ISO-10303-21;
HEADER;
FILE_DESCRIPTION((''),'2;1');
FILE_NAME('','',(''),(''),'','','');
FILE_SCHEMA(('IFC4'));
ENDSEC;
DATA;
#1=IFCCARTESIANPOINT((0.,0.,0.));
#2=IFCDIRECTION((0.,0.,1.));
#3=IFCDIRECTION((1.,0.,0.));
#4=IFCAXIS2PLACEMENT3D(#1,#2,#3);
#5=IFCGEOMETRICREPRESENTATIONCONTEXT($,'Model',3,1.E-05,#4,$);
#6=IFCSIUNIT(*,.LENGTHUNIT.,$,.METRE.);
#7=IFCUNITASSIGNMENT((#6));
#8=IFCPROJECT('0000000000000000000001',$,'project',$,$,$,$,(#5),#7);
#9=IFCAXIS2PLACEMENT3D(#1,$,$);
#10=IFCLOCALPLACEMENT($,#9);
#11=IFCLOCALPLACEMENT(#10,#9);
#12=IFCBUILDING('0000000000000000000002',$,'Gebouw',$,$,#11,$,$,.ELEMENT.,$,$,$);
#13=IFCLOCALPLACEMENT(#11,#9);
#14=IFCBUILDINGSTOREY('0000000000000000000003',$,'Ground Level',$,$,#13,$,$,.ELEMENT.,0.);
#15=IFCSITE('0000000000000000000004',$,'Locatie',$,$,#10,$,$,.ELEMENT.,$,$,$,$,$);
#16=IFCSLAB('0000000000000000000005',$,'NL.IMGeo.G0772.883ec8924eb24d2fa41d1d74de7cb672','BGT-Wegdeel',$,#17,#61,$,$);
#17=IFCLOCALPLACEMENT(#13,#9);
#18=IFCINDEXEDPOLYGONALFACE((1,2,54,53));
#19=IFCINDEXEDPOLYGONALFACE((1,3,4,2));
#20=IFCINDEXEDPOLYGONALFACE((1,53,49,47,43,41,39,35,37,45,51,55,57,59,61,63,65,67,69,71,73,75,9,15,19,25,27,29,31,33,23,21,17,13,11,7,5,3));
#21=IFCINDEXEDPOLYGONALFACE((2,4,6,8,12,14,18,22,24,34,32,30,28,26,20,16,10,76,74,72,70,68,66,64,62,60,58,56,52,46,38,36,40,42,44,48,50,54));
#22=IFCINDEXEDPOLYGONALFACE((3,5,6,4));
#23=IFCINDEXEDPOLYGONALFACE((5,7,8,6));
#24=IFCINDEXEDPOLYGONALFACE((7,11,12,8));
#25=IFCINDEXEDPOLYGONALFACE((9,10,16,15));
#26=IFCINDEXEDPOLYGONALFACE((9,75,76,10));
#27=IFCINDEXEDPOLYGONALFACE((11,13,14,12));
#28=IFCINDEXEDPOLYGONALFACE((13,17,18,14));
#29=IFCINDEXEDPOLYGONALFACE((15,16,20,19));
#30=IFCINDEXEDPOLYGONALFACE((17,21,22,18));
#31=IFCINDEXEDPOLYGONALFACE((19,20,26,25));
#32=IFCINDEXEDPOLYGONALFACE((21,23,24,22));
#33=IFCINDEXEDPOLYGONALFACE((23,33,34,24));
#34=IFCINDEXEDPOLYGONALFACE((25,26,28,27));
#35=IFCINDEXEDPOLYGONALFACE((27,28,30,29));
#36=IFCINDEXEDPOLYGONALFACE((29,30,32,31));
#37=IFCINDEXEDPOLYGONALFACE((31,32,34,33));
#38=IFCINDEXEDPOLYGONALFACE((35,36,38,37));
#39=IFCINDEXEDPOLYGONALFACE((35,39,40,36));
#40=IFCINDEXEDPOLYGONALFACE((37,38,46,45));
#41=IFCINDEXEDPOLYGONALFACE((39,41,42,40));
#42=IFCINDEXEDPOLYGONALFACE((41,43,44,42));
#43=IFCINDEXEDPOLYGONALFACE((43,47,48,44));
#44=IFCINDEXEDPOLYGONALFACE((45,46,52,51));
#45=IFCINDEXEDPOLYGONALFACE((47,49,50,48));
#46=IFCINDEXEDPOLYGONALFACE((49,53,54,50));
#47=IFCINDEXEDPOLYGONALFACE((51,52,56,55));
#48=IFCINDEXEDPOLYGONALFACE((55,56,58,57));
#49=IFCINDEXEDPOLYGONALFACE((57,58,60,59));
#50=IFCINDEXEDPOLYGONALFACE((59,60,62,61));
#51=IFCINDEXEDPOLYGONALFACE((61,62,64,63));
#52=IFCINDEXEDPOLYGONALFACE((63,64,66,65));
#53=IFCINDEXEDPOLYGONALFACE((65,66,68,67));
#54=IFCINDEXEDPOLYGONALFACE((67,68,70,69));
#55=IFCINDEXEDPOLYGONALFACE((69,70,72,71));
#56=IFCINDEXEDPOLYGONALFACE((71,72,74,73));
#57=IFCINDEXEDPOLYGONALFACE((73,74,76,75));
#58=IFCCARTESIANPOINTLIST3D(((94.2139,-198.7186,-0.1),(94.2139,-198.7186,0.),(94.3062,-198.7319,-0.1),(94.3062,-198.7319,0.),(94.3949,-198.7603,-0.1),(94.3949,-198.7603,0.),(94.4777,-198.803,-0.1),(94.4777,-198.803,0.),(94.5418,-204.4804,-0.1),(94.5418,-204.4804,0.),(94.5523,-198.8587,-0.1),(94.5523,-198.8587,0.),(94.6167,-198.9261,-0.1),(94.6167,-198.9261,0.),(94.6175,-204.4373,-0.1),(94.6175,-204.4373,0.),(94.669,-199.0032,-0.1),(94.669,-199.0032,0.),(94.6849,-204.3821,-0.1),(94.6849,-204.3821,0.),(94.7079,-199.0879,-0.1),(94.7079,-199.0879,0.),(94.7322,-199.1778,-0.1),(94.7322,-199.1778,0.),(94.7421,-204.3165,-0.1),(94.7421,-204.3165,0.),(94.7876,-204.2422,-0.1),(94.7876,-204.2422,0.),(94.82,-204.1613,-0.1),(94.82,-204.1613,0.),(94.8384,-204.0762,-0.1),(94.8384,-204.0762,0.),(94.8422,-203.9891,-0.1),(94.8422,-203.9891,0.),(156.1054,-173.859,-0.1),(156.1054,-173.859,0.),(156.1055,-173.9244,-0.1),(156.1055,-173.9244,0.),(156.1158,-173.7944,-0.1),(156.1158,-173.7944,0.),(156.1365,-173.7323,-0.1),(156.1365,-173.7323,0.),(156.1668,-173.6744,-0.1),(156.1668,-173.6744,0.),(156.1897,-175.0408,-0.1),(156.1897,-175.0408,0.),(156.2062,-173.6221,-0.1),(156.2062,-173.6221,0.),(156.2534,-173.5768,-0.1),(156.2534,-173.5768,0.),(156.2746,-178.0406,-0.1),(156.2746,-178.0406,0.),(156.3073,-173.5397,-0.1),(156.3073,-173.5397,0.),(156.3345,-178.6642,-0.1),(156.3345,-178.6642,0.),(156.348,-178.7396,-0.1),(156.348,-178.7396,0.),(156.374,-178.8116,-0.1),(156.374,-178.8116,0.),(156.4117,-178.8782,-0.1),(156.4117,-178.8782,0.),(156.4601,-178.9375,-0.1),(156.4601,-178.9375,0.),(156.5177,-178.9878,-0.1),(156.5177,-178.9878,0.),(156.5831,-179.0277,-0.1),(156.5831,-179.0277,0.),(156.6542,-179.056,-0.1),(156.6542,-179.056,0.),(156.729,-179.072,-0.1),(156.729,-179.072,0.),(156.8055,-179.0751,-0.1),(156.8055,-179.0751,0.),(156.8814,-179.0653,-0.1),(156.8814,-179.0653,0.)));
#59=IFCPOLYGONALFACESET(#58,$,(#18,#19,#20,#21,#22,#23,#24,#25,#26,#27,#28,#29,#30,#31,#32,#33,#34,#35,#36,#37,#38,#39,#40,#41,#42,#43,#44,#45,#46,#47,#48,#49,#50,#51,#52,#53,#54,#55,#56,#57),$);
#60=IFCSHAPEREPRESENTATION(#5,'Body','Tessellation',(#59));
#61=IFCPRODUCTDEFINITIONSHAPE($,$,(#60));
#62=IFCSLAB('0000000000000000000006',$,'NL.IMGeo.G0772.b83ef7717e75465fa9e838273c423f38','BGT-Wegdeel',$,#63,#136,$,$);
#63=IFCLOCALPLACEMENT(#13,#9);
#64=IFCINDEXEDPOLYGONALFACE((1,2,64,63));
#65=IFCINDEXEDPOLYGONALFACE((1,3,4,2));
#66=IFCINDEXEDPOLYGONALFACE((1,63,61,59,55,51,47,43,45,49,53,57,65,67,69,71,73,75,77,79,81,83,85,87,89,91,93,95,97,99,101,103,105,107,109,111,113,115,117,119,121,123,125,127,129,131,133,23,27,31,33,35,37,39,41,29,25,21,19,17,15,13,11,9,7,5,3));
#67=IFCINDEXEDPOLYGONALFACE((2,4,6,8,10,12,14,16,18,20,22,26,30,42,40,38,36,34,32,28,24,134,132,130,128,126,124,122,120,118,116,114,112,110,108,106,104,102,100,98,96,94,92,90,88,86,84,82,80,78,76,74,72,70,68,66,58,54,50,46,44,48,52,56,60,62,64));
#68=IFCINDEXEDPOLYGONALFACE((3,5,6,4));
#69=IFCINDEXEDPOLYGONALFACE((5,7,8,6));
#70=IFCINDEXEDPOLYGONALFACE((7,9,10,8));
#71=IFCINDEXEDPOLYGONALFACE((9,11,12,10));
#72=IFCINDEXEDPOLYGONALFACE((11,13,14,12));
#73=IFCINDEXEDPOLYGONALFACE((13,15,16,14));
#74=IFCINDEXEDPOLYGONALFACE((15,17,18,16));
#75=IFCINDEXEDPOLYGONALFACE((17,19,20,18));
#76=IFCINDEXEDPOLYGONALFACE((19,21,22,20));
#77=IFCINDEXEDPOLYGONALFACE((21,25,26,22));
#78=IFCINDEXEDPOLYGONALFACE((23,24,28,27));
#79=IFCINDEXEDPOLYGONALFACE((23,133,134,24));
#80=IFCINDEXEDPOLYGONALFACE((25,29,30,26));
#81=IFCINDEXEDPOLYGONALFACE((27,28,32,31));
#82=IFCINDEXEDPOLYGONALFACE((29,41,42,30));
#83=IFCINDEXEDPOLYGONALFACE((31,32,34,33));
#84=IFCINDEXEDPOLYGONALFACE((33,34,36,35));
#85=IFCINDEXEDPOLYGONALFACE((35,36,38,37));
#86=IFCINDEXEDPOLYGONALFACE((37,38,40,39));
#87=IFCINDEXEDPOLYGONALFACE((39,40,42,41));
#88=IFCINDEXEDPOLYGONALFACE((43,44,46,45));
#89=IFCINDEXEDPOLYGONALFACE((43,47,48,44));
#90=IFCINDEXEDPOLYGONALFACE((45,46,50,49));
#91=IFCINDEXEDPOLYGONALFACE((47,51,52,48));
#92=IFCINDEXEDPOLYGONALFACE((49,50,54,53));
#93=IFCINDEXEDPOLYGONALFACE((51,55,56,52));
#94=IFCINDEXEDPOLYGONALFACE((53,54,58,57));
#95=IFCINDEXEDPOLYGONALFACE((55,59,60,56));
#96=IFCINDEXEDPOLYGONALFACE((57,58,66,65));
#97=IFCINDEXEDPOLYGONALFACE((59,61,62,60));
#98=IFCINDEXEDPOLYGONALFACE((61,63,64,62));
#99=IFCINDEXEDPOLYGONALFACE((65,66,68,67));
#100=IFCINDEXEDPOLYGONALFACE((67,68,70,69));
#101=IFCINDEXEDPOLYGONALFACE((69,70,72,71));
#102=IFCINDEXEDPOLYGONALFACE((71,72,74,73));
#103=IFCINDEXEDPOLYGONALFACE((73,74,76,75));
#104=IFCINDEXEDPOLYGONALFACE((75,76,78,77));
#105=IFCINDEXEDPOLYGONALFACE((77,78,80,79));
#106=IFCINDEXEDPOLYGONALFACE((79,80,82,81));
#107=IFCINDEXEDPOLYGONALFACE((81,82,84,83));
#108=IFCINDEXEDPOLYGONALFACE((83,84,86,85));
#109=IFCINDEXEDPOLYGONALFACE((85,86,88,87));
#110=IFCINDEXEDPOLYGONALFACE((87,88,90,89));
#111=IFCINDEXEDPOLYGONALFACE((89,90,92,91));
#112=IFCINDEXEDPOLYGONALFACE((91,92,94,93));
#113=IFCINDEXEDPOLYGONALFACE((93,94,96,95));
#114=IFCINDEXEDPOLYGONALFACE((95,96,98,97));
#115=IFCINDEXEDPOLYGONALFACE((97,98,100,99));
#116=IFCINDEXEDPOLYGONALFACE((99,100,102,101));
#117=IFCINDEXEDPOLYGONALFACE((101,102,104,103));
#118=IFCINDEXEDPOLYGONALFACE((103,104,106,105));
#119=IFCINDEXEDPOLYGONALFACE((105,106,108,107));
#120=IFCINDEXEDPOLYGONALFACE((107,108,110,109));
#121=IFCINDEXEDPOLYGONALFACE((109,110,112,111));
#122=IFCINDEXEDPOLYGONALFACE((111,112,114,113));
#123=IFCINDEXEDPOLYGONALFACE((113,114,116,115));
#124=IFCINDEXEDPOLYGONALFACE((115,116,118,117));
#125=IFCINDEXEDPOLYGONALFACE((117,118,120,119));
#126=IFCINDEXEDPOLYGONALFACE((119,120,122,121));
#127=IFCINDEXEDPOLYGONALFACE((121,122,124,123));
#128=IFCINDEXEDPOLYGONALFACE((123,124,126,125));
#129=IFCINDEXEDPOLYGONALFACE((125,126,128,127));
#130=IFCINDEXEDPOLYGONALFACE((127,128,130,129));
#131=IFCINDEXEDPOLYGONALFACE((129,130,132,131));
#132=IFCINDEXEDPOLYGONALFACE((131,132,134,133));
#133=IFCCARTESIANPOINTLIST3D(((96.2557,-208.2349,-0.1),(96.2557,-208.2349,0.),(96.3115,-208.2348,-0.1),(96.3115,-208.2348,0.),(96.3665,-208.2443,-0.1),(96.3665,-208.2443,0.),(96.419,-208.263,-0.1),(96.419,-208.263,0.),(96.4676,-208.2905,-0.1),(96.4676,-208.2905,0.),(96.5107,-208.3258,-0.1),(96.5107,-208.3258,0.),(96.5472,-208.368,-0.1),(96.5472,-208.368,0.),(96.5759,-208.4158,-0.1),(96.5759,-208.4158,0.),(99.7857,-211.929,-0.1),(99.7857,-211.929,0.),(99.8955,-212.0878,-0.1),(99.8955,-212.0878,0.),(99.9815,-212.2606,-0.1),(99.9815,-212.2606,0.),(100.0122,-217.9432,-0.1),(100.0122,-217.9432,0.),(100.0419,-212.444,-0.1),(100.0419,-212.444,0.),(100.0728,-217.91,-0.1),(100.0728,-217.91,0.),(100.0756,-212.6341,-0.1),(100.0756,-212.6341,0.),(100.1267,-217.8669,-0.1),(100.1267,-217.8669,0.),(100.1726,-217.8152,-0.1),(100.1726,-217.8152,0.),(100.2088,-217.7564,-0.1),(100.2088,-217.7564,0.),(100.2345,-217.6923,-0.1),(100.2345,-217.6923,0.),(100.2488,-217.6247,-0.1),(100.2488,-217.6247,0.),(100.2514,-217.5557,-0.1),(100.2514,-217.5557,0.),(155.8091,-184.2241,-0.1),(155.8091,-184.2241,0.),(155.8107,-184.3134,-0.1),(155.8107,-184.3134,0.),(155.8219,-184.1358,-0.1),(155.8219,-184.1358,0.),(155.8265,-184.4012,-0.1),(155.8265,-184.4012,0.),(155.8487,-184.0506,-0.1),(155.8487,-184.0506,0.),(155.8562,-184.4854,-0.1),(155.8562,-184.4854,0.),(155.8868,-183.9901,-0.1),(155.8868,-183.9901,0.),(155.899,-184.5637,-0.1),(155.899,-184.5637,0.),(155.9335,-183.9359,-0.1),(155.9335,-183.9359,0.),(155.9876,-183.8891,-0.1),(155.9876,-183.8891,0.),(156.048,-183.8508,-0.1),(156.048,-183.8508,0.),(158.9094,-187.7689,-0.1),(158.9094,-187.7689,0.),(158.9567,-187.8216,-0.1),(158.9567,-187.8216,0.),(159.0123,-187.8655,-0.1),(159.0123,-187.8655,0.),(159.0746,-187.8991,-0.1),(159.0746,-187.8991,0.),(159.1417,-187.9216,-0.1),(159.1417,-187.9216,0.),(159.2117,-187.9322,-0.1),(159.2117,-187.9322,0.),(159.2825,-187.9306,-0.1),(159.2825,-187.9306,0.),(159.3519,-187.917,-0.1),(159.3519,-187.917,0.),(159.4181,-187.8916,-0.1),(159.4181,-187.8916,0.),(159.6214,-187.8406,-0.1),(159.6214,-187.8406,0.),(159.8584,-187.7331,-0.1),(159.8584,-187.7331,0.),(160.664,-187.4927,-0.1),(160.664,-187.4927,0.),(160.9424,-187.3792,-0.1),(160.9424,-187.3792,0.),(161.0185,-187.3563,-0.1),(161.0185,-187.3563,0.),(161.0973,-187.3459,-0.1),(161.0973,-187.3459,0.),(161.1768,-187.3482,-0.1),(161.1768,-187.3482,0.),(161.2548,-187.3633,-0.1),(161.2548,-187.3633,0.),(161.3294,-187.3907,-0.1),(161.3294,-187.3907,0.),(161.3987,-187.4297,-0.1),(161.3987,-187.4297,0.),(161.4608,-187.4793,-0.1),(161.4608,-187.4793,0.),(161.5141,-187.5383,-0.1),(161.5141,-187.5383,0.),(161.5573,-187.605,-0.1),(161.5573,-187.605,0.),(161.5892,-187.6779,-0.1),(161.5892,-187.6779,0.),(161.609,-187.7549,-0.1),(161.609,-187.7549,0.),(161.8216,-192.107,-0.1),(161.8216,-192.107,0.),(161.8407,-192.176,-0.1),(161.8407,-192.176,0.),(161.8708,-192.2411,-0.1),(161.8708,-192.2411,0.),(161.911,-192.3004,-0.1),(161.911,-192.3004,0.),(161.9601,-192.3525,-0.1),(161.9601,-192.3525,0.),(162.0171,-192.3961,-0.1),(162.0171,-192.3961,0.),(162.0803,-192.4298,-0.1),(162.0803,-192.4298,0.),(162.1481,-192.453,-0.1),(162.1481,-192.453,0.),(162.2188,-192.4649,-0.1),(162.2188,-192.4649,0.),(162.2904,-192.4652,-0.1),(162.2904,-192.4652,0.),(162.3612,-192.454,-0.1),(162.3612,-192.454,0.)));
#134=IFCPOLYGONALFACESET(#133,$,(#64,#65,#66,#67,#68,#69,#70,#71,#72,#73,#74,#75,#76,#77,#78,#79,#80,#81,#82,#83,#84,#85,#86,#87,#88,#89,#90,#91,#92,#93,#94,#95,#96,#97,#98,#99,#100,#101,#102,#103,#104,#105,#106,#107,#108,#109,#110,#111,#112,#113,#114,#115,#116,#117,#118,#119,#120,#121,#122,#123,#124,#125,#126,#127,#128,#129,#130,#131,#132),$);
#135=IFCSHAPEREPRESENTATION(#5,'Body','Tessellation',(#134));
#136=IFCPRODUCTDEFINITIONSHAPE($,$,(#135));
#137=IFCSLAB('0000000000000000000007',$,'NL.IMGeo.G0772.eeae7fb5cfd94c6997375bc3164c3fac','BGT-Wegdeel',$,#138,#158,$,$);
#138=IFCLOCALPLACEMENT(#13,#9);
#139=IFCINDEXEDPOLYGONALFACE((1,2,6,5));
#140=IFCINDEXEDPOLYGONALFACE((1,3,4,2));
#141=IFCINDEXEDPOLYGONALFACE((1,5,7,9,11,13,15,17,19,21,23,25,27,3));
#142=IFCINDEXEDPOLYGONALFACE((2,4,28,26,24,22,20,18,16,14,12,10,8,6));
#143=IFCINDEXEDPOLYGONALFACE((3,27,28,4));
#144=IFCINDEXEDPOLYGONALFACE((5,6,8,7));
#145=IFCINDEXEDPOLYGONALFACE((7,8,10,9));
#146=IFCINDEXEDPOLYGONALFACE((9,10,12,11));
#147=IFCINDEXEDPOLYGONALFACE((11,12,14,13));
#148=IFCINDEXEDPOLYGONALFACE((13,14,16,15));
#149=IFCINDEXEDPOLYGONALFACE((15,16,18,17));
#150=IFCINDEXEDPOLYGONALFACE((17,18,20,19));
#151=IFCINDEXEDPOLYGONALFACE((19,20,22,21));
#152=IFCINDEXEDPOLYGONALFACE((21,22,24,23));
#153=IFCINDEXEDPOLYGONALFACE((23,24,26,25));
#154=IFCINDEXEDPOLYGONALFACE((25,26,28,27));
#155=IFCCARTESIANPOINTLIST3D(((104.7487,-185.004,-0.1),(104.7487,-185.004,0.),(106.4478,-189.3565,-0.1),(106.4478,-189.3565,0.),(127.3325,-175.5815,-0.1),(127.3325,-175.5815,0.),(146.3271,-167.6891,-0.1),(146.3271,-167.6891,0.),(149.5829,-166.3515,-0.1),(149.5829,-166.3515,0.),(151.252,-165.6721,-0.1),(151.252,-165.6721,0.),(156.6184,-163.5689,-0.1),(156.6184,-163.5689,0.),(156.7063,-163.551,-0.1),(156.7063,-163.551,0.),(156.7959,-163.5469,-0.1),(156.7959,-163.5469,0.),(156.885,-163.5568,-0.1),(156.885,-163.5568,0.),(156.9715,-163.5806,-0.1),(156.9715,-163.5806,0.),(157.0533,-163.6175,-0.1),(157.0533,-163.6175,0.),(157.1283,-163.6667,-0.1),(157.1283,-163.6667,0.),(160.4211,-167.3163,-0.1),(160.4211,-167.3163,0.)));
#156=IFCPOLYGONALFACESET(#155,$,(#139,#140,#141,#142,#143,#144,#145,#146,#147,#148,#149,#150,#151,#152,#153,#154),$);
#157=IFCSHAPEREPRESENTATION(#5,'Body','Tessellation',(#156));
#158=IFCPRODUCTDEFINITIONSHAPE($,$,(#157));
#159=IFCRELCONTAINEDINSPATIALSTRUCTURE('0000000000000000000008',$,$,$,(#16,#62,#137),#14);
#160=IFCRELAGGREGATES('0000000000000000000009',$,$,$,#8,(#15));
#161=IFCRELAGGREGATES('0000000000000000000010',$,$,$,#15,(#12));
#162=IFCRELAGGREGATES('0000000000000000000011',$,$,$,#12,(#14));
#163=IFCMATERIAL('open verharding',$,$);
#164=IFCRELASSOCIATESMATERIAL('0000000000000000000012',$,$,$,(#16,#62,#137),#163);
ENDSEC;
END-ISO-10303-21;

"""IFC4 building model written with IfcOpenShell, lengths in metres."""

from ifc_helpers import new_model, si_unit, frame, origin, origin_with_axes, place, context, project, spatial, polyline, outline, extrude, material, element, save


model = new_model("IFC4")

# Units and contexts
model_context = context("Model", 3, precision=1e-05, world=origin_with_axes())
ifc_project = project(units=[si_unit("LENGTHUNIT", "METRE")], contexts=[model_context])

# Site, building, storey
site_placement = place(None, origin())
site = spatial("IfcSite", under=ifc_project, at=site_placement, Name="Locatie", CompositionType="ELEMENT")
building_placement = place(site_placement, origin())
building = spatial("IfcBuilding", under=site, at=building_placement, Name="Gebouw", CompositionType="ELEMENT")
storey_placement = place(building_placement, origin())
storey = spatial("IfcBuildingStorey", under=building, at=storey_placement, Name="Ground Level", CompositionType="ELEMENT", Elevation=0.0)

# Slabs
ifc_material_1 = material(Name="open verharding")
slab_1_placement = place(storey_placement, origin())
element("IfcSlab", 1, at=slab_1_placement, inside=storey, material=ifc_material_1, Name="NL.IMGeo.G0772.883ec8924eb24d2fa41d1d74de7cb672", Description="BGT-Wegdeel", context=model_context, shape_type="SweptSolid", body=[
    extrude(outline(polyline([(156.3073, -173.5397), (156.2534, -173.5768), (156.2062, -173.6221), (156.1668, -173.6744), (156.1365, -173.7323), (156.1158, -173.7944), (156.1054, -173.859), (156.1055, -173.9244), (156.1897, -175.0408), (156.2746, -178.0406), (156.3345, -178.6642), (156.348, -178.7396), (156.374, -178.8116), (156.4117, -178.8782), (156.4601, -178.9375), (156.5177, -178.9878), (156.5831, -179.0277), (156.6542, -179.056), (156.729, -179.072), (156.8055, -179.0751), (156.8814, -179.0653), (94.5418, -204.4804), (94.6175, -204.4373), (94.6849, -204.3821), (94.7421, -204.3165), (94.7876, -204.2422), (94.82, -204.1613), (94.8384, -204.0762), (94.8422, -203.9891), (94.7322, -199.1778), (94.7079, -199.0879), (94.669, -199.0032), (94.6167, -198.9261), (94.5523, -198.8587), (94.4777, -198.803), (94.3949, -198.7603), (94.3062, -198.7319), (94.2139, -198.7186), (156.3073, -173.5397)])), frame((0.0, 0.0, -0.1), z_axis=(0.0, 0.0, 1.0), x_axis=(1.0, 0.0, 0.0)), (0.0, 0.0, 1.0), 0.1),
])
slab_2_placement = place(storey_placement, origin())
element("IfcSlab", 2, at=slab_2_placement, inside=storey, material=ifc_material_1, Name="NL.IMGeo.G0772.b83ef7717e75465fa9e838273c423f38", Description="BGT-Wegdeel", context=model_context, shape_type="SweptSolid", body=[
    extrude(outline(polyline([(156.048, -183.8508), (155.9876, -183.8891), (155.9335, -183.9359), (155.8868, -183.9901), (155.8487, -184.0506), (155.8219, -184.1358), (155.8091, -184.2241), (155.8107, -184.3134), (155.8265, -184.4012), (155.8562, -184.4854), (155.899, -184.5637), (158.9094, -187.7689), (158.9567, -187.8216), (159.0123, -187.8655), (159.0746, -187.8991), (159.1417, -187.9216), (159.2117, -187.9322), (159.2825, -187.9306), (159.3519, -187.917), (159.4181, -187.8916), (159.6214, -187.8406), (159.8584, -187.7331), (160.664, -187.4927), (160.9424, -187.3792), (161.0185, -187.3563), (161.0973, -187.3459), (161.1768, -187.3482), (161.2548, -187.3633), (161.3294, -187.3907), (161.3987, -187.4297), (161.4608, -187.4793), (161.5141, -187.5383), (161.5573, -187.605), (161.5892, -187.6779), (161.609, -187.7549), (161.8216, -192.107), (161.8407, -192.176), (161.8708, -192.2411), (161.911, -192.3004), (161.9601, -192.3525), (162.0171, -192.3961), (162.0803, -192.4298), (162.1481, -192.453), (162.2188, -192.4649), (162.2904, -192.4652), (162.3612, -192.454), (100.0122, -217.9432), (100.0728, -217.91), (100.1267, -217.8669), (100.1726, -217.8152), (100.2088, -217.7564), (100.2345, -217.6923), (100.2488, -217.6247), (100.2514, -217.5557), (100.0756, -212.6341), (100.0419, -212.444), (99.9815, -212.2606), (99.8955, -212.0878), (99.7857, -211.929), (96.5759, -208.4158), (96.5472, -208.368), (96.5107, -208.3258), (96.4676, -208.2905), (96.419, -208.263), (96.3665, -208.2443), (96.3115, -208.2348), (96.2557, -208.2349), (156.048, -183.8508)])), frame((0.0, 0.0, -0.1), z_axis=(0.0, 0.0, 1.0), x_axis=(1.0, 0.0, 0.0)), (0.0, 0.0, 1.0), 0.1),
])
slab_3_placement = place(storey_placement, origin())
element("IfcSlab", 3, at=slab_3_placement, inside=storey, material=ifc_material_1, Name="NL.IMGeo.G0772.eeae7fb5cfd94c6997375bc3164c3fac", Description="BGT-Wegdeel", context=model_context, shape_type="SweptSolid", body=[
    extrude(outline(polyline([(146.3271, -167.6891), (149.5829, -166.3515), (151.252, -165.6721), (156.6184, -163.5689), (156.7063, -163.551), (156.7959, -163.5469), (156.885, -163.5568), (156.9715, -163.5806), (157.0533, -163.6175), (157.1283, -163.6667), (160.4211, -167.3163), (106.4478, -189.3565), (104.7487, -185.004), (127.3325, -175.5815), (146.3271, -167.6891)])), frame((0.0, 0.0, -0.1), z_axis=(0.0, 0.0, 1.0), x_axis=(1.0, 0.0, 0.0)), (0.0, 0.0, 1.0), 0.1),
])

save(model, "model.ifc")
